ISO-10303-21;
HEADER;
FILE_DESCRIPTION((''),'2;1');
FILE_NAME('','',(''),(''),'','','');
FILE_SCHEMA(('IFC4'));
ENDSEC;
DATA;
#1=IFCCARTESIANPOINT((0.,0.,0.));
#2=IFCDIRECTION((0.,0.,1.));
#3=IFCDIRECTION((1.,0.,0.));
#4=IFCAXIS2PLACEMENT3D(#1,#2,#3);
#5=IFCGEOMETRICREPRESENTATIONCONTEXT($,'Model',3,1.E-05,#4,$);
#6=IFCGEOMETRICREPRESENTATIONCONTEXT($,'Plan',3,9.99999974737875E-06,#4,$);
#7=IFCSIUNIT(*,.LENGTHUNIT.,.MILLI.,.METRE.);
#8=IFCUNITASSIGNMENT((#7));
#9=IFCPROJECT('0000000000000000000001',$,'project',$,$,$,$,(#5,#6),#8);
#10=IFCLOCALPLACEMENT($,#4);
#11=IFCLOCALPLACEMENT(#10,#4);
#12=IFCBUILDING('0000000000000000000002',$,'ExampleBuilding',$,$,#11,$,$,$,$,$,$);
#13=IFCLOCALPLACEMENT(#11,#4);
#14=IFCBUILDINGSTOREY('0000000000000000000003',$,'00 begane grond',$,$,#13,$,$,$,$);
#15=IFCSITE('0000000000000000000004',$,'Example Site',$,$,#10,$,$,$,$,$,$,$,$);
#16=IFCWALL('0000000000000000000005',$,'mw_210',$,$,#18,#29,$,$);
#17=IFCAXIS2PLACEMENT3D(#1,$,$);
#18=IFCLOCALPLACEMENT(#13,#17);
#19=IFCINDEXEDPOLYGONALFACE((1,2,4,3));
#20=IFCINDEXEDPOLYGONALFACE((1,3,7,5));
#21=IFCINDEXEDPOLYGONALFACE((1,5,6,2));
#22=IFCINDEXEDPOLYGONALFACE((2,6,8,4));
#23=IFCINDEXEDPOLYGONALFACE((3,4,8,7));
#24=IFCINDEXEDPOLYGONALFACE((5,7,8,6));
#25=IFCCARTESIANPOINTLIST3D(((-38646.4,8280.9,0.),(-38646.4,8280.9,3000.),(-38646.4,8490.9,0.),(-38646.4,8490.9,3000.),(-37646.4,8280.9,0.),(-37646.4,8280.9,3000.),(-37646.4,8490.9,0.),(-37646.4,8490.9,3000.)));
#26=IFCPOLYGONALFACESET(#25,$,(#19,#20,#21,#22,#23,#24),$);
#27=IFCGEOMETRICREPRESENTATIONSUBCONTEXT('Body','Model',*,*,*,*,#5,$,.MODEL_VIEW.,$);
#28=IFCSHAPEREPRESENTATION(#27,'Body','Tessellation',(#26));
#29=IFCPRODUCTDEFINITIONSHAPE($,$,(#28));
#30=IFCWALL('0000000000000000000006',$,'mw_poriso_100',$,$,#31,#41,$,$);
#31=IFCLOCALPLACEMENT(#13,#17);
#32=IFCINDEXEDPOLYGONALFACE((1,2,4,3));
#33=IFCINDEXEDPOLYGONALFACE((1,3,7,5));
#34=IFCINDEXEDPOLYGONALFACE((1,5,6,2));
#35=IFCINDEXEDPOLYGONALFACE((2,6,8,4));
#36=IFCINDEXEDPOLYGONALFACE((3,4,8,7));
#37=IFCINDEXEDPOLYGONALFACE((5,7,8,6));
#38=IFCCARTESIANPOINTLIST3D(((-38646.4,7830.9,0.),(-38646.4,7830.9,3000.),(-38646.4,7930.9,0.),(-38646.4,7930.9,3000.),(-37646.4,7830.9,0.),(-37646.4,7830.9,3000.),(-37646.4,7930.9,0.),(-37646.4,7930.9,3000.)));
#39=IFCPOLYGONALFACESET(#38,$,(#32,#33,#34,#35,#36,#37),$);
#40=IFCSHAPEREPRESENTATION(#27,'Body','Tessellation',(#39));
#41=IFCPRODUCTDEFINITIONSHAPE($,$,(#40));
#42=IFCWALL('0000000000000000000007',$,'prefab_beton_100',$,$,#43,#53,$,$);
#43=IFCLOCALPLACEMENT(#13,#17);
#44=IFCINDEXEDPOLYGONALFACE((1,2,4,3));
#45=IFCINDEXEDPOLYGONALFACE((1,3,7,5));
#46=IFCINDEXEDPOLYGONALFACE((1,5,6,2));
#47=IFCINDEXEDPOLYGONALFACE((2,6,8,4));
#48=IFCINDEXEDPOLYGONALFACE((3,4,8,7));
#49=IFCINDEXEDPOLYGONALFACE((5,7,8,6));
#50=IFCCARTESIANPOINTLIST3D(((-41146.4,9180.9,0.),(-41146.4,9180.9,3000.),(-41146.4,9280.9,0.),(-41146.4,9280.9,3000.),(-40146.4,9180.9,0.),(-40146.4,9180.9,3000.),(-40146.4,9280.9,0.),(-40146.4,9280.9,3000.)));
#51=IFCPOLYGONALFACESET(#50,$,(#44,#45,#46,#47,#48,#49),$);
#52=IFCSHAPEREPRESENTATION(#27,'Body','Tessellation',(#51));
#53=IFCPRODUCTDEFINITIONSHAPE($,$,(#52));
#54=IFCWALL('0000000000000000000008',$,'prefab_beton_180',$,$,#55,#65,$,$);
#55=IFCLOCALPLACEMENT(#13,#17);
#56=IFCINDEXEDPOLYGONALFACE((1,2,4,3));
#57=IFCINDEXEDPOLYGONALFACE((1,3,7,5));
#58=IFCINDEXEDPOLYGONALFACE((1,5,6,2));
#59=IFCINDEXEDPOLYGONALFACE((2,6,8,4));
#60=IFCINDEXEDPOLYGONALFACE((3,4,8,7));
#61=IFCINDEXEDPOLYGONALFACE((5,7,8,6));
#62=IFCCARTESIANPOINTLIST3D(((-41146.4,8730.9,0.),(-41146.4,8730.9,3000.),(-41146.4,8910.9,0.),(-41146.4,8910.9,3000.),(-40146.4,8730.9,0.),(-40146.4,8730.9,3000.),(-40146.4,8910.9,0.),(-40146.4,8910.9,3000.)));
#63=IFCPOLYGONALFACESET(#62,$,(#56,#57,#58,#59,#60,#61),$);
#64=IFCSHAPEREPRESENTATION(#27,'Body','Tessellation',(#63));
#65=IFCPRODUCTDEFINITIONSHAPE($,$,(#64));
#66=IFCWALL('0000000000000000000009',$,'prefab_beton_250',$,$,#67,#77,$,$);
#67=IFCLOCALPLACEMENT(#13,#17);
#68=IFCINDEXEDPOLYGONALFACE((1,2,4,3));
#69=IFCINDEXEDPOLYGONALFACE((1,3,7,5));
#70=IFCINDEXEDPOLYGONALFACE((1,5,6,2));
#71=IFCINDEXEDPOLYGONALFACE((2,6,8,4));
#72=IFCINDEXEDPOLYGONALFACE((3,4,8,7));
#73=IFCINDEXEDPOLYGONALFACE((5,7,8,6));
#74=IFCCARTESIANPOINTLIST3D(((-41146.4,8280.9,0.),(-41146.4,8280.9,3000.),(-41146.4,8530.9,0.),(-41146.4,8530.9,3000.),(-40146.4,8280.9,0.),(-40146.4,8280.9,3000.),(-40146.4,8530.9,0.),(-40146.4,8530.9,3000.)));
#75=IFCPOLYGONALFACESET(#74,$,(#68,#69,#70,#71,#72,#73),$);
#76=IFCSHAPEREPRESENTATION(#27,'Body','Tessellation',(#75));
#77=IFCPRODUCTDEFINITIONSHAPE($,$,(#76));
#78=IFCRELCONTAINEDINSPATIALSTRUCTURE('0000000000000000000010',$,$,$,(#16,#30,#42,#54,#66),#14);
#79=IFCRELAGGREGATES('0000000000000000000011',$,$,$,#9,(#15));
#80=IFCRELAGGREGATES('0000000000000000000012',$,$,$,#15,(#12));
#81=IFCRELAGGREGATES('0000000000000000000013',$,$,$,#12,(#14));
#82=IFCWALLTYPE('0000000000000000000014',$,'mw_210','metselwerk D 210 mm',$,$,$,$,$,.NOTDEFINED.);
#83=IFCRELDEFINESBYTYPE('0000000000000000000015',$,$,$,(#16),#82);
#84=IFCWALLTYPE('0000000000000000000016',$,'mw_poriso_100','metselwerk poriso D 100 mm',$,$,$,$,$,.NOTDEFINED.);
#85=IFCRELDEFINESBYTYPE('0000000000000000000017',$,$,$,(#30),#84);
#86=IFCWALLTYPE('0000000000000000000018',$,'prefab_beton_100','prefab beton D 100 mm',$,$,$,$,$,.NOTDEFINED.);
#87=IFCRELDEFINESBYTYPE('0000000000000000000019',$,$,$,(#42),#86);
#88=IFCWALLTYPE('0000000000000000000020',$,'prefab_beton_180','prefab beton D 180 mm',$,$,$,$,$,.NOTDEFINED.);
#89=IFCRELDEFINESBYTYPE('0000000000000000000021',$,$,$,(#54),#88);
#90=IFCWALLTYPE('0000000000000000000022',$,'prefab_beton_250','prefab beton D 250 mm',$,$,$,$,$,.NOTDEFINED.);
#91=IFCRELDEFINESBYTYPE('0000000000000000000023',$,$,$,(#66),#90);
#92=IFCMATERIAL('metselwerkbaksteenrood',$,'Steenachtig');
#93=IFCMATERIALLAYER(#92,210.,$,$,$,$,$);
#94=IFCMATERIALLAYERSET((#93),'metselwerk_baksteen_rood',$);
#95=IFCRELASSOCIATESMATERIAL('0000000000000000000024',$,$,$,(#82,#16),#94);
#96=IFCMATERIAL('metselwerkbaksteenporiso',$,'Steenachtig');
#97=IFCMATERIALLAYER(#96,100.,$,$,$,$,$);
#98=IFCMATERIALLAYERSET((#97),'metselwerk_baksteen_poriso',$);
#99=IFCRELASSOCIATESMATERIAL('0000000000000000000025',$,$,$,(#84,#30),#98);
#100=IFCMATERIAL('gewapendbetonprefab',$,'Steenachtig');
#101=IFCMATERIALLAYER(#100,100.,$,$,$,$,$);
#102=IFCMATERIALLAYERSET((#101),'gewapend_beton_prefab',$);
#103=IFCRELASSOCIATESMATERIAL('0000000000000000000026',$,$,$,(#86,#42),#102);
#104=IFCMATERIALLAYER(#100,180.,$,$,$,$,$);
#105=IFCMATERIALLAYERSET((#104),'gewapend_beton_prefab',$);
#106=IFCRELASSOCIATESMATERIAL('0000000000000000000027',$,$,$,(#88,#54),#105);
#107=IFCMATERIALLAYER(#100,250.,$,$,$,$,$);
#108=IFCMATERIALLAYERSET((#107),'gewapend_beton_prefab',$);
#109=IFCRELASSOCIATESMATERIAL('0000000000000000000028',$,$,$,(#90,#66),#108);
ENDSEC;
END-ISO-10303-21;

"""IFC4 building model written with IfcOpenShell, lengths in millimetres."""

from ifc_helpers import new_model, si_unit, frame, origin_with_axes, place, context, subcontext, project, spatial, indexed_curve, outline, extrude, material, layer, layer_set, layer_usage, type_object, element, save


model = new_model("IFC4")

# Units and contexts
model_context = context("Model", 3, precision=1e-05, world=origin_with_axes())
plan_context = context("Plan", 3, precision=9.99999974737875e-06, world=origin_with_axes())
body_context = subcontext(model_context, "Body", "Model", "MODEL_VIEW")
ifc_project = project(units=[si_unit("LENGTHUNIT", "METRE", prefix="MILLI")], contexts=[model_context, plan_context])

# Site, building, storey
site_placement = place(None, frame((0.0, 0.0, 0.0), z_axis=(0.0, 0.0, 1.0), x_axis=(1.0, 0.0, 0.0)))
site = spatial("IfcSite", under=ifc_project, at=site_placement, Name="Example Site")
building_placement = place(site_placement, frame((0.0, 0.0, 0.0), z_axis=(0.0, 0.0, 1.0), x_axis=(1.0, 0.0, 0.0)))
building = spatial("IfcBuilding", under=site, at=building_placement, Name="ExampleBuilding")
storey_placement = place(building_placement, frame((0.0, 0.0, 0.0), z_axis=(0.0, 0.0, 1.0), x_axis=(1.0, 0.0, 0.0)))
storey = spatial("IfcBuildingStorey", under=building, at=storey_placement, Name="00 begane grond")

# Walls
ifc_material_1 = material(Name="metselwerkbaksteenrood", Category="Steenachtig")
ifc_layer_1 = layer(ifc_material_1, 210.0)
ifc_layer_set_1 = layer_set([ifc_layer_1], Name="metselwerk_baksteen_rood")
ifc_layer_usage_1 = layer_usage(ifc_layer_set_1, "AXIS2", "POSITIVE", 0.0)
wall_type_1 = type_object("IfcWallType", Name="mw_210", Description="metselwerk D 210 mm", PredefinedType="NOTDEFINED", material=ifc_layer_set_1)
wall_1_placement = place(storey_placement, frame((-38646.4, 8280.9, 0.0), z_axis=(0.0, 0.0, 1.0), x_axis=(1.0, 0.0, 0.0)))
element("IfcWall", 1, at=wall_1_placement, inside=storey, type_object=wall_type_1, material=ifc_layer_usage_1, Name="mw_210", context=body_context, shape_type="SweptSolid", body=[
    extrude(outline(indexed_curve([(0.0, 0.0), (0.0, 210.0), (1000.0, 210.0), (1000.0, 0.0), (0.0, 0.0)], self_intersect=False)), origin_with_axes(), (0.0, 0.0, 1.0), 3000.0),
])
ifc_material_2 = material(Name="metselwerkbaksteenporiso", Category="Steenachtig")
ifc_layer_2 = layer(ifc_material_2, 100.0)
ifc_layer_set_2 = layer_set([ifc_layer_2], Name="metselwerk_baksteen_poriso")
ifc_layer_usage_2 = layer_usage(ifc_layer_set_2, "AXIS2", "POSITIVE", 0.0)
wall_type_2 = type_object("IfcWallType", Name="mw_poriso_100", Description="metselwerk poriso D 100 mm", PredefinedType="NOTDEFINED", material=ifc_layer_set_2)
wall_2_placement = place(storey_placement, frame((-38646.4, 7830.9, 0.0), z_axis=(0.0, 0.0, 1.0), x_axis=(1.0, 0.0, 0.0)))
element("IfcWall", 2, at=wall_2_placement, inside=storey, type_object=wall_type_2, material=ifc_layer_usage_2, Name="mw_poriso_100", context=body_context, shape_type="SweptSolid", body=[
    extrude(outline(indexed_curve([(0.0, 0.0), (0.0, 100.0), (1000.0, 100.0), (1000.0, 0.0), (0.0, 0.0)], self_intersect=False)), origin_with_axes(), (0.0, 0.0, 1.0), 3000.0),
])
ifc_material_3 = material(Name="gewapendbetonprefab", Category="Steenachtig")
ifc_layer_3 = layer(ifc_material_3, 100.0)
ifc_layer_set_3 = layer_set([ifc_layer_3], Name="gewapend_beton_prefab")
ifc_layer_usage_3 = layer_usage(ifc_layer_set_3, "AXIS2", "POSITIVE", 0.0)
wall_type_3 = type_object("IfcWallType", Name="prefab_beton_100", Description="prefab beton D 100 mm", PredefinedType="NOTDEFINED", material=ifc_layer_set_3)
wall_3_placement = place(storey_placement, frame((-41146.4, 9180.9, 0.0), z_axis=(0.0, 0.0, 1.0), x_axis=(1.0, 0.0, 0.0)))
element("IfcWall", 3, at=wall_3_placement, inside=storey, type_object=wall_type_3, material=ifc_layer_usage_3, Name="prefab_beton_100", context=body_context, shape_type="SweptSolid", body=[
    extrude(outline(indexed_curve([(0.0, 0.0), (0.0, 100.0), (1000.0, 100.0), (1000.0, 0.0), (0.0, 0.0)], self_intersect=False)), origin_with_axes(), (0.0, 0.0, 1.0), 3000.0),
])
ifc_layer_4 = layer(ifc_material_3, 180.0)
ifc_layer_set_4 = layer_set([ifc_layer_4], Name="gewapend_beton_prefab")
ifc_layer_usage_4 = layer_usage(ifc_layer_set_4, "AXIS2", "POSITIVE", 0.0)
wall_type_4 = type_object("IfcWallType", Name="prefab_beton_180", Description="prefab beton D 180 mm", PredefinedType="NOTDEFINED", material=ifc_layer_set_4)
wall_4_placement = place(storey_placement, frame((-41146.4, 8730.9, 0.0), z_axis=(0.0, 0.0, 1.0), x_axis=(1.0, 0.0, 0.0)))
element("IfcWall", 4, at=wall_4_placement, inside=storey, type_object=wall_type_4, material=ifc_layer_usage_4, Name="prefab_beton_180", context=body_context, shape_type="SweptSolid", body=[
    extrude(outline(indexed_curve([(0.0, 0.0), (0.0, 180.0), (1000.0, 180.0), (1000.0, 0.0), (0.0, 0.0)], self_intersect=False)), origin_with_axes(), (0.0, 0.0, 1.0), 3000.0),
])
ifc_layer_5 = layer(ifc_material_3, 250.0)
ifc_layer_set_5 = layer_set([ifc_layer_5], Name="gewapend_beton_prefab")
ifc_layer_usage_5 = layer_usage(ifc_layer_set_5, "AXIS2", "POSITIVE", 0.0)
wall_type_5 = type_object("IfcWallType", Name="prefab_beton_250", Description="prefab beton D 250 mm", PredefinedType="NOTDEFINED", material=ifc_layer_set_5)
wall_5_placement = place(storey_placement, frame((-41146.4, 8280.9, 0.0), z_axis=(0.0, 0.0, 1.0), x_axis=(1.0, 0.0, 0.0)))
element("IfcWall", 5, at=wall_5_placement, inside=storey, type_object=wall_type_5, material=ifc_layer_usage_5, Name="prefab_beton_250", context=body_context, shape_type="SweptSolid", body=[
    extrude(outline(indexed_curve([(0.0, 0.0), (0.0, 250.0), (1000.0, 250.0), (1000.0, 0.0), (0.0, 0.0)], self_intersect=False)), origin_with_axes(), (0.0, 0.0, 1.0), 3000.0),
])

save(model, "model.ifc")
